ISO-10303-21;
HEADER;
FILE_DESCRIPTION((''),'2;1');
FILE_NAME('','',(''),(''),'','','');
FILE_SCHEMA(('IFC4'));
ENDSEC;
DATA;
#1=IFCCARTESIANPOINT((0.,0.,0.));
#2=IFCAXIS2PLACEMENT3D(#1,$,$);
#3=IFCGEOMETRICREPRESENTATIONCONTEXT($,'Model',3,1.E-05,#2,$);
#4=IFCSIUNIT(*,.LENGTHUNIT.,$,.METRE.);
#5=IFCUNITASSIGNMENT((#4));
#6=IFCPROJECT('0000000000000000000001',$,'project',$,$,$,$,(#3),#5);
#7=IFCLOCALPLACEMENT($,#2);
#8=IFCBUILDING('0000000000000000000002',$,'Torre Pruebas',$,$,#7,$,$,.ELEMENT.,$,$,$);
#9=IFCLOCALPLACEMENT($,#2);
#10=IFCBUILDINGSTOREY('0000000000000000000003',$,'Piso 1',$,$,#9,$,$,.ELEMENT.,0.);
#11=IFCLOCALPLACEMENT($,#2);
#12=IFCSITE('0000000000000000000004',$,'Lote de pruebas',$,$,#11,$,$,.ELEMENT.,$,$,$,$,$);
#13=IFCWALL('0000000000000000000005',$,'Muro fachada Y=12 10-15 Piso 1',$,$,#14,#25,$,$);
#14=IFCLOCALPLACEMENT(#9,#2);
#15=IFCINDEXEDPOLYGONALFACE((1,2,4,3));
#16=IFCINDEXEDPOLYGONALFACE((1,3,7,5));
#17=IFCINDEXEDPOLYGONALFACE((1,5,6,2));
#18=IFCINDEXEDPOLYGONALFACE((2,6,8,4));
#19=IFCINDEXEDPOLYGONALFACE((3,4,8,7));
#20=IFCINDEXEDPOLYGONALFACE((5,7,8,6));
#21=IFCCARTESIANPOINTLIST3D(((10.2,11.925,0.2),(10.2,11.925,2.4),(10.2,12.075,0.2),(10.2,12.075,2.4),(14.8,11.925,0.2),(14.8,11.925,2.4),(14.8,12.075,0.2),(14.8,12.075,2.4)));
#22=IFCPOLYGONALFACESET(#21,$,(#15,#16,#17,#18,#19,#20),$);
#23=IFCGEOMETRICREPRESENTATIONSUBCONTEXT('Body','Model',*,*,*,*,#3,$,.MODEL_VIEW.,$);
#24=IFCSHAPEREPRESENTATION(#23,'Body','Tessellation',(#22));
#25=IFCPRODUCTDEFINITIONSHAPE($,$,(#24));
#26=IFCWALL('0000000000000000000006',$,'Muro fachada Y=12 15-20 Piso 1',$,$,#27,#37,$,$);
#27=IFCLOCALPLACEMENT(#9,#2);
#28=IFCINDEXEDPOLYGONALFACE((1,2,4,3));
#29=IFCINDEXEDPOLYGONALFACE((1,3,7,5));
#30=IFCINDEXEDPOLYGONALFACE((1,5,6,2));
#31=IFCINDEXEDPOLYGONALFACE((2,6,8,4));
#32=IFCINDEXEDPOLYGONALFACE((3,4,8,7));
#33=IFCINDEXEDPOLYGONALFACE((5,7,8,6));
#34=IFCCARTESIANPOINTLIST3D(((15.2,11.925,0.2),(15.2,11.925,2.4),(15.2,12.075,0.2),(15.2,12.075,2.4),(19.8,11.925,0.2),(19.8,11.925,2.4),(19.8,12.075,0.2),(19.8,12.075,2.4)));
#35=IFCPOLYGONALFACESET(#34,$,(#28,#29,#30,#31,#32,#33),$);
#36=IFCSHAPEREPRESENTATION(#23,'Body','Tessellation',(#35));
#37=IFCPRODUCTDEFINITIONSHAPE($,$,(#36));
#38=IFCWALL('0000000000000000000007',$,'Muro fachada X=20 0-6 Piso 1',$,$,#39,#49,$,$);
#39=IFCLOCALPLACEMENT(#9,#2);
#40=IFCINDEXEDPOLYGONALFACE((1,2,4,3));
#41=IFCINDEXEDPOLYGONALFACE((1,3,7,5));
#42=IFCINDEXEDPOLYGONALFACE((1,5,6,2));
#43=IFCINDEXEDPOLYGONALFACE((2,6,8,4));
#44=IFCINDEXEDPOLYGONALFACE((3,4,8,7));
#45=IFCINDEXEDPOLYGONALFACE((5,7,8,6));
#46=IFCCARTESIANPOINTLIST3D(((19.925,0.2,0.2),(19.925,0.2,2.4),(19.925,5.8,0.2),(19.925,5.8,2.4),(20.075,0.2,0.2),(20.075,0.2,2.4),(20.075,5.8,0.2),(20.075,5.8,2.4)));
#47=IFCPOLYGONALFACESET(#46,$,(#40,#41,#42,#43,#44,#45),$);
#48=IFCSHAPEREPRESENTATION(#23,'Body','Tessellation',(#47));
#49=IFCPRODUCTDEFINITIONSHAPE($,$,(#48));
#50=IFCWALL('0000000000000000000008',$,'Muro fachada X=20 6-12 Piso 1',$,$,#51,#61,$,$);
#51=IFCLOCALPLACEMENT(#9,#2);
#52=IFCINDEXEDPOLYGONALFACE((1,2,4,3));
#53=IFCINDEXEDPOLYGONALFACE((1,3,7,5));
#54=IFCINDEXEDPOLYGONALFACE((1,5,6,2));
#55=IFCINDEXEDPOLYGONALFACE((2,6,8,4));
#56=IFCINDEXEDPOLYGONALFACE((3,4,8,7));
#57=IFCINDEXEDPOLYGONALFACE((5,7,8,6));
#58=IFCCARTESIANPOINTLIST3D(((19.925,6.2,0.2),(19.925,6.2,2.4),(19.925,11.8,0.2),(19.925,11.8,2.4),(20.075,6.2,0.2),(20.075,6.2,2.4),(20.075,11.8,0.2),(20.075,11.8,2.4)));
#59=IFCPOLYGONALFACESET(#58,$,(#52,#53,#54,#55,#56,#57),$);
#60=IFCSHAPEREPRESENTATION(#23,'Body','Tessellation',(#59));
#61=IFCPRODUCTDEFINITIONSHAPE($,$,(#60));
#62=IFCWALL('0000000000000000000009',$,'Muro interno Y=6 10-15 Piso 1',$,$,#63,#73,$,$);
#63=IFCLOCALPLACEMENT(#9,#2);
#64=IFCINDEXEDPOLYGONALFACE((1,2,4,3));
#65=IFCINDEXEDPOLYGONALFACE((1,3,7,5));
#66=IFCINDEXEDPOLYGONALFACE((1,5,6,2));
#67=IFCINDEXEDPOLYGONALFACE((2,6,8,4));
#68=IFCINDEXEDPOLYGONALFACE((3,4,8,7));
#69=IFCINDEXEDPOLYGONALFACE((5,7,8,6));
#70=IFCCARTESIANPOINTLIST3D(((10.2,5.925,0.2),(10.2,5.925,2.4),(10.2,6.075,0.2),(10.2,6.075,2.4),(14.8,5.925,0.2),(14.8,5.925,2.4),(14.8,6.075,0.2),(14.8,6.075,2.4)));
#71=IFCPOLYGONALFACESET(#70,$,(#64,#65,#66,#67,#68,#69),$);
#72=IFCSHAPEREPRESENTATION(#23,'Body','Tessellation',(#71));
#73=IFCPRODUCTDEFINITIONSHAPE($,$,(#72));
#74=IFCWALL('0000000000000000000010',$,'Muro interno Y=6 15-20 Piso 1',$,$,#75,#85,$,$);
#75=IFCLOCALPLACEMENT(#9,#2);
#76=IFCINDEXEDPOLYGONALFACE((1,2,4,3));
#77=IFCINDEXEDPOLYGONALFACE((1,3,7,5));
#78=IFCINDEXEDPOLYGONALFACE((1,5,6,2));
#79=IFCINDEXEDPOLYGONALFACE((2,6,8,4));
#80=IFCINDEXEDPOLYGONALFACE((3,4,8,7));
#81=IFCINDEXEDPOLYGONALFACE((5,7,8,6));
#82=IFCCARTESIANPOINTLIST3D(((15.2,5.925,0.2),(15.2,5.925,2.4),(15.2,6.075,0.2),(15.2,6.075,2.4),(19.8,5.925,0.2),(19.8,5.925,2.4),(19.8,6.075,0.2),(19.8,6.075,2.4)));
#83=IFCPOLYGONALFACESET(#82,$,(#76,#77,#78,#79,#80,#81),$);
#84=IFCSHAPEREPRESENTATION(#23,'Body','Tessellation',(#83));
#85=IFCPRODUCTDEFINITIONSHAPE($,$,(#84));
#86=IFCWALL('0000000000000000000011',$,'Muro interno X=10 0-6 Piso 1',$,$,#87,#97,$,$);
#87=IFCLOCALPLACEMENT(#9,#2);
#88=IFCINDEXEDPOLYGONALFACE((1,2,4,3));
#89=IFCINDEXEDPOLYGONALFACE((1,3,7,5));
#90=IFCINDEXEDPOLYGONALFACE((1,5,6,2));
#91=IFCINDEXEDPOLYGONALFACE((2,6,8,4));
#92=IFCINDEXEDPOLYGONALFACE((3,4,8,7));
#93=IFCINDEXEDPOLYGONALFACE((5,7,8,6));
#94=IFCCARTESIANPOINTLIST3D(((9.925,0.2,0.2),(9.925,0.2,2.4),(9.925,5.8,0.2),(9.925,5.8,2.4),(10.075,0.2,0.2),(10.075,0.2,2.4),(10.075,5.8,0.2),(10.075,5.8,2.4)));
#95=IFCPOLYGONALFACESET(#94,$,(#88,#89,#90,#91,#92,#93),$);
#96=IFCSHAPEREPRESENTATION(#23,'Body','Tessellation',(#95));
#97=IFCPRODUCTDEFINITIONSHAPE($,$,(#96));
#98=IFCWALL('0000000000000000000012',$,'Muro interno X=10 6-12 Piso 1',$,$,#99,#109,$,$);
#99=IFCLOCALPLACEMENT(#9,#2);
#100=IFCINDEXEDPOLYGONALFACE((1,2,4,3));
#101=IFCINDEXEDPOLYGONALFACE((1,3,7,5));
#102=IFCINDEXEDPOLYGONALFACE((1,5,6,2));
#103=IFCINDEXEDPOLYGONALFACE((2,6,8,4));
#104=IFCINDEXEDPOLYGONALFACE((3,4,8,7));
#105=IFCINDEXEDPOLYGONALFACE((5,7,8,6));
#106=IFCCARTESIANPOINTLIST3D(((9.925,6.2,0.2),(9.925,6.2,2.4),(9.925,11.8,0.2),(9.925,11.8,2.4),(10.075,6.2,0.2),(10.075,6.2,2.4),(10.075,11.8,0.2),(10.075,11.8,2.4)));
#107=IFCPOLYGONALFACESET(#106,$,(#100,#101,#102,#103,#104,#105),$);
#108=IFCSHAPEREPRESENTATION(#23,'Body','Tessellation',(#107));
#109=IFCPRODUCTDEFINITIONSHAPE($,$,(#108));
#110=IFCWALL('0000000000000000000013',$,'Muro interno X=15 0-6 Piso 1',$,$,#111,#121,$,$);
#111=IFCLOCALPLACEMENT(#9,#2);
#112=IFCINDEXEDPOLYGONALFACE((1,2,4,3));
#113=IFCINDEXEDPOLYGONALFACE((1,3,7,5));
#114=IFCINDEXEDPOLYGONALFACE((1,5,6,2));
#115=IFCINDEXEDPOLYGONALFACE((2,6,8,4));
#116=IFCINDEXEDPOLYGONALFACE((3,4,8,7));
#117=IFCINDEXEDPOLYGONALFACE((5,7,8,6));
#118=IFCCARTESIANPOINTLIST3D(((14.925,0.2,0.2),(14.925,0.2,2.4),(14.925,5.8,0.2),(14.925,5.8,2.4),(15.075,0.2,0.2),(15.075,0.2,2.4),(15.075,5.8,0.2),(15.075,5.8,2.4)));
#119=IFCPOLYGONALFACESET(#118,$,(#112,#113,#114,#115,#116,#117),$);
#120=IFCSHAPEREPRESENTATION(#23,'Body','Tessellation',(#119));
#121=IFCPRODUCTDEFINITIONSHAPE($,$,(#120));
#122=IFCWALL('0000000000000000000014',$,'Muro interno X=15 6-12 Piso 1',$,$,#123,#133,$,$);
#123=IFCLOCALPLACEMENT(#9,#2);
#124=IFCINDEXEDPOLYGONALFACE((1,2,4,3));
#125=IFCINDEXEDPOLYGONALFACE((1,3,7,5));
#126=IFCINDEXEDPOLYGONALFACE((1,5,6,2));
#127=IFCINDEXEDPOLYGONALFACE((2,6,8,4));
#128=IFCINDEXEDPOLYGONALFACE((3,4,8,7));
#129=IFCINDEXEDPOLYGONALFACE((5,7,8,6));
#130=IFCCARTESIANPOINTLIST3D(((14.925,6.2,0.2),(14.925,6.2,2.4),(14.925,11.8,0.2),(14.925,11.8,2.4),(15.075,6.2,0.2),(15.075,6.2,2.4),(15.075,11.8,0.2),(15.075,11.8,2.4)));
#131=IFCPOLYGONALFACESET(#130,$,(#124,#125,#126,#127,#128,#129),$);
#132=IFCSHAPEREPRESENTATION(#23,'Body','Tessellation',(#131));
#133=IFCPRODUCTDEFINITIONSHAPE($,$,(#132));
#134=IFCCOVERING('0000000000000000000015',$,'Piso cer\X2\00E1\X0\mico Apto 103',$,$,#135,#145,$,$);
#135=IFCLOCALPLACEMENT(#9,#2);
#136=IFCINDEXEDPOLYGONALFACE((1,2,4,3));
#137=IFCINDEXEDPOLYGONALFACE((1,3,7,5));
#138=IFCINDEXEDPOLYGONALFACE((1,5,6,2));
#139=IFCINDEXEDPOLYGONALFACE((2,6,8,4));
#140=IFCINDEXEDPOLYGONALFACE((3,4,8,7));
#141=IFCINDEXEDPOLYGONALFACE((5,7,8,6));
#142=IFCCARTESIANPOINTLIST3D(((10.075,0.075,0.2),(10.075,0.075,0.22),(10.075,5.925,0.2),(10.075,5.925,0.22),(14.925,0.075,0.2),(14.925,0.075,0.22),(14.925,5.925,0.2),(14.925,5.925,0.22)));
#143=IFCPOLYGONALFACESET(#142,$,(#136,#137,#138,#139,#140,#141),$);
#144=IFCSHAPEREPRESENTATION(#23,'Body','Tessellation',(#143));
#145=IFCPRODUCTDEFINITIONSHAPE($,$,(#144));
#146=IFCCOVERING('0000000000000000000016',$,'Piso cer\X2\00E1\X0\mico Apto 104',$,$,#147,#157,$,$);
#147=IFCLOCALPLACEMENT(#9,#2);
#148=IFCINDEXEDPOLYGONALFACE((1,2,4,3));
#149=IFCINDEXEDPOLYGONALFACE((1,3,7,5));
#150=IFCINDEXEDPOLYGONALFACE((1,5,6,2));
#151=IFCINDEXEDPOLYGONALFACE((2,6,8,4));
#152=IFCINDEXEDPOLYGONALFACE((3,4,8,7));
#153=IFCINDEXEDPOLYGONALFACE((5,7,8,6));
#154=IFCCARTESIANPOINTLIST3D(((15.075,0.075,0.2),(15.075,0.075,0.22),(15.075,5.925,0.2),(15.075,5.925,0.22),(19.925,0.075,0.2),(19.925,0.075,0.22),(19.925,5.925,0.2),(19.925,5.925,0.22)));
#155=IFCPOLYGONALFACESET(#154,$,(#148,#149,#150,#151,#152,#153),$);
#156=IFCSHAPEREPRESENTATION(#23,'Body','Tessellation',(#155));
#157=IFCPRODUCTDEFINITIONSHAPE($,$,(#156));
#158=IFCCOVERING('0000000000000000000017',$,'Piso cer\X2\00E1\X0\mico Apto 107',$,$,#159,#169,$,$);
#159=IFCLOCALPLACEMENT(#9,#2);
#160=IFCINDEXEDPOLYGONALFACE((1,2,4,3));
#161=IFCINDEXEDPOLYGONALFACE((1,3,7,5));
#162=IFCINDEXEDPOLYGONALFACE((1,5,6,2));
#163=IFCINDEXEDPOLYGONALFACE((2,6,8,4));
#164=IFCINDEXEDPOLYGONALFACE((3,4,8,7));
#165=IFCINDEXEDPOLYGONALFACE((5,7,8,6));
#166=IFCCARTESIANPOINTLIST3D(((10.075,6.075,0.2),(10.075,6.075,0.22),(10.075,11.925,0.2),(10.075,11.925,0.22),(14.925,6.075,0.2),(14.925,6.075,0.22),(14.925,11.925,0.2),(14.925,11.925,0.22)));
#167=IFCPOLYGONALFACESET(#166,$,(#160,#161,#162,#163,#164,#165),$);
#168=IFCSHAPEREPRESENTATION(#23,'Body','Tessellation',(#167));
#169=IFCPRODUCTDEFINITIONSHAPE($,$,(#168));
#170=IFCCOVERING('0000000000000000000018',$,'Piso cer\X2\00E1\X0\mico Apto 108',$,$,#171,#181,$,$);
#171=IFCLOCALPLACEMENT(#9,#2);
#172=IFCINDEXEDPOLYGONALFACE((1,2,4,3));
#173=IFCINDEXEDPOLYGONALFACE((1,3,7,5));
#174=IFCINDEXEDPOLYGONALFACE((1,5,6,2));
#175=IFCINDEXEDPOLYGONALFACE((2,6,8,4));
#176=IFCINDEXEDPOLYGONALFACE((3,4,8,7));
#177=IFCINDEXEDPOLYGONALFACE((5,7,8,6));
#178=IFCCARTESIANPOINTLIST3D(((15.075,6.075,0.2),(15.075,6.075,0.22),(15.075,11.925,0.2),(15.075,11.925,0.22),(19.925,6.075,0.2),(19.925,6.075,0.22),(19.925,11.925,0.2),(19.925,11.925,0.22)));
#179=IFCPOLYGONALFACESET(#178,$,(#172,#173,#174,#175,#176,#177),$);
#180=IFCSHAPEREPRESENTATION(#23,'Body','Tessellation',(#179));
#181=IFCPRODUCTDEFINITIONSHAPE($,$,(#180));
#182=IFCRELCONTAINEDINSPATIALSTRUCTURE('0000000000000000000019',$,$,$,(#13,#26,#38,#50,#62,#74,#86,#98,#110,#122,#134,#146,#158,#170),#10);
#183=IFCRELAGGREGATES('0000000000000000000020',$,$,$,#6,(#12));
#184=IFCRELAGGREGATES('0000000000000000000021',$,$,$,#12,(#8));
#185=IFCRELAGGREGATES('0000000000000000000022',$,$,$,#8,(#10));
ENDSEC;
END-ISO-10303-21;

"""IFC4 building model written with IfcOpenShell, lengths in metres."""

from ifc_helpers import new_model, si_unit, frame, origin, origin_2d, place, context, subcontext, project, spatial, rectangle, extrude, element, save


model = new_model("IFC4")

# Units and contexts
model_context = context("Model", 3, precision=1e-05, world=origin())
body_context = subcontext(model_context, "Body", "Model", "MODEL_VIEW")
ifc_project = project(units=[si_unit("LENGTHUNIT", "METRE")], contexts=[model_context])

# Site, building, storey
site_placement = place(None, origin())
site = spatial("IfcSite", under=ifc_project, at=site_placement, Name="Lote de pruebas", CompositionType="ELEMENT")
building_placement = place(None, origin())
building = spatial("IfcBuilding", under=site, at=building_placement, Name="Torre Pruebas", CompositionType="ELEMENT")
storey_placement = place(None, origin())
storey = spatial("IfcBuildingStorey", under=building, at=storey_placement, Name="Piso 1", CompositionType="ELEMENT", Elevation=0.0)

# Walls
for number, where, name in (
    (1, (12.5, 12.0, 0.2), "Muro fachada Y=12 10-15 Piso 1"),
    (2, (17.5, 12.0, 0.2), "Muro fachada Y=12 15-20 Piso 1"),
):
    element("IfcWall", number, at=place(None, frame(where)), inside=storey, Name=name, context=body_context, shape_type="SweptSolid", body=[
        extrude(rectangle(XDim=4.6, YDim=0.15, at=origin_2d()), origin(), (0.0, 0.0, 1.0), 2.2),
    ])
for number, where, name in (
    (3, (20.0, 3.0, 0.2), "Muro fachada X=20 0-6 Piso 1"),
    (4, (20.0, 9.0, 0.2), "Muro fachada X=20 6-12 Piso 1"),
):
    element("IfcWall", number, at=place(None, frame(where)), inside=storey, Name=name, context=body_context, shape_type="SweptSolid", body=[
        extrude(rectangle(XDim=0.15, YDim=5.6, at=origin_2d()), origin(), (0.0, 0.0, 1.0), 2.2),
    ])
for number, where, name in (
    (5, (12.5, 6.0, 0.2), "Muro interno Y=6 10-15 Piso 1"),
    (6, (17.5, 6.0, 0.2), "Muro interno Y=6 15-20 Piso 1"),
):
    element("IfcWall", number, at=place(None, frame(where)), inside=storey, Name=name, context=body_context, shape_type="SweptSolid", body=[
        extrude(rectangle(XDim=4.6, YDim=0.15, at=origin_2d()), origin(), (0.0, 0.0, 1.0), 2.2),
    ])
for number, where, name in (
    (7, (10.0, 3.0, 0.2), "Muro interno X=10 0-6 Piso 1"),
    (8, (10.0, 9.0, 0.2), "Muro interno X=10 6-12 Piso 1"),
    (9, (15.0, 3.0, 0.2), "Muro interno X=15 0-6 Piso 1"),
    (10, (15.0, 9.0, 0.2), "Muro interno X=15 6-12 Piso 1"),
):
    element("IfcWall", number, at=place(None, frame(where)), inside=storey, Name=name, context=body_context, shape_type="SweptSolid", body=[
        extrude(rectangle(XDim=0.15, YDim=5.6, at=origin_2d()), origin(), (0.0, 0.0, 1.0), 2.2),
    ])

# Coverings
for number, where, name in (
    (11, (12.5, 3.0, 0.2), "Piso cerámico Apto 103"),
    (12, (17.5, 3.0, 0.2), "Piso cerámico Apto 104"),
    (13, (12.5, 9.0, 0.2), "Piso cerámico Apto 107"),
    (14, (17.5, 9.0, 0.2), "Piso cerámico Apto 108"),
):
    element("IfcCovering", number, at=place(None, frame(where)), inside=storey, Name=name, context=body_context, shape_type="SweptSolid", body=[
        extrude(rectangle(XDim=4.85, YDim=5.85, at=origin_2d()), origin(), (0.0, 0.0, 1.0), 0.02),
    ])

save(model, "model.ifc")
